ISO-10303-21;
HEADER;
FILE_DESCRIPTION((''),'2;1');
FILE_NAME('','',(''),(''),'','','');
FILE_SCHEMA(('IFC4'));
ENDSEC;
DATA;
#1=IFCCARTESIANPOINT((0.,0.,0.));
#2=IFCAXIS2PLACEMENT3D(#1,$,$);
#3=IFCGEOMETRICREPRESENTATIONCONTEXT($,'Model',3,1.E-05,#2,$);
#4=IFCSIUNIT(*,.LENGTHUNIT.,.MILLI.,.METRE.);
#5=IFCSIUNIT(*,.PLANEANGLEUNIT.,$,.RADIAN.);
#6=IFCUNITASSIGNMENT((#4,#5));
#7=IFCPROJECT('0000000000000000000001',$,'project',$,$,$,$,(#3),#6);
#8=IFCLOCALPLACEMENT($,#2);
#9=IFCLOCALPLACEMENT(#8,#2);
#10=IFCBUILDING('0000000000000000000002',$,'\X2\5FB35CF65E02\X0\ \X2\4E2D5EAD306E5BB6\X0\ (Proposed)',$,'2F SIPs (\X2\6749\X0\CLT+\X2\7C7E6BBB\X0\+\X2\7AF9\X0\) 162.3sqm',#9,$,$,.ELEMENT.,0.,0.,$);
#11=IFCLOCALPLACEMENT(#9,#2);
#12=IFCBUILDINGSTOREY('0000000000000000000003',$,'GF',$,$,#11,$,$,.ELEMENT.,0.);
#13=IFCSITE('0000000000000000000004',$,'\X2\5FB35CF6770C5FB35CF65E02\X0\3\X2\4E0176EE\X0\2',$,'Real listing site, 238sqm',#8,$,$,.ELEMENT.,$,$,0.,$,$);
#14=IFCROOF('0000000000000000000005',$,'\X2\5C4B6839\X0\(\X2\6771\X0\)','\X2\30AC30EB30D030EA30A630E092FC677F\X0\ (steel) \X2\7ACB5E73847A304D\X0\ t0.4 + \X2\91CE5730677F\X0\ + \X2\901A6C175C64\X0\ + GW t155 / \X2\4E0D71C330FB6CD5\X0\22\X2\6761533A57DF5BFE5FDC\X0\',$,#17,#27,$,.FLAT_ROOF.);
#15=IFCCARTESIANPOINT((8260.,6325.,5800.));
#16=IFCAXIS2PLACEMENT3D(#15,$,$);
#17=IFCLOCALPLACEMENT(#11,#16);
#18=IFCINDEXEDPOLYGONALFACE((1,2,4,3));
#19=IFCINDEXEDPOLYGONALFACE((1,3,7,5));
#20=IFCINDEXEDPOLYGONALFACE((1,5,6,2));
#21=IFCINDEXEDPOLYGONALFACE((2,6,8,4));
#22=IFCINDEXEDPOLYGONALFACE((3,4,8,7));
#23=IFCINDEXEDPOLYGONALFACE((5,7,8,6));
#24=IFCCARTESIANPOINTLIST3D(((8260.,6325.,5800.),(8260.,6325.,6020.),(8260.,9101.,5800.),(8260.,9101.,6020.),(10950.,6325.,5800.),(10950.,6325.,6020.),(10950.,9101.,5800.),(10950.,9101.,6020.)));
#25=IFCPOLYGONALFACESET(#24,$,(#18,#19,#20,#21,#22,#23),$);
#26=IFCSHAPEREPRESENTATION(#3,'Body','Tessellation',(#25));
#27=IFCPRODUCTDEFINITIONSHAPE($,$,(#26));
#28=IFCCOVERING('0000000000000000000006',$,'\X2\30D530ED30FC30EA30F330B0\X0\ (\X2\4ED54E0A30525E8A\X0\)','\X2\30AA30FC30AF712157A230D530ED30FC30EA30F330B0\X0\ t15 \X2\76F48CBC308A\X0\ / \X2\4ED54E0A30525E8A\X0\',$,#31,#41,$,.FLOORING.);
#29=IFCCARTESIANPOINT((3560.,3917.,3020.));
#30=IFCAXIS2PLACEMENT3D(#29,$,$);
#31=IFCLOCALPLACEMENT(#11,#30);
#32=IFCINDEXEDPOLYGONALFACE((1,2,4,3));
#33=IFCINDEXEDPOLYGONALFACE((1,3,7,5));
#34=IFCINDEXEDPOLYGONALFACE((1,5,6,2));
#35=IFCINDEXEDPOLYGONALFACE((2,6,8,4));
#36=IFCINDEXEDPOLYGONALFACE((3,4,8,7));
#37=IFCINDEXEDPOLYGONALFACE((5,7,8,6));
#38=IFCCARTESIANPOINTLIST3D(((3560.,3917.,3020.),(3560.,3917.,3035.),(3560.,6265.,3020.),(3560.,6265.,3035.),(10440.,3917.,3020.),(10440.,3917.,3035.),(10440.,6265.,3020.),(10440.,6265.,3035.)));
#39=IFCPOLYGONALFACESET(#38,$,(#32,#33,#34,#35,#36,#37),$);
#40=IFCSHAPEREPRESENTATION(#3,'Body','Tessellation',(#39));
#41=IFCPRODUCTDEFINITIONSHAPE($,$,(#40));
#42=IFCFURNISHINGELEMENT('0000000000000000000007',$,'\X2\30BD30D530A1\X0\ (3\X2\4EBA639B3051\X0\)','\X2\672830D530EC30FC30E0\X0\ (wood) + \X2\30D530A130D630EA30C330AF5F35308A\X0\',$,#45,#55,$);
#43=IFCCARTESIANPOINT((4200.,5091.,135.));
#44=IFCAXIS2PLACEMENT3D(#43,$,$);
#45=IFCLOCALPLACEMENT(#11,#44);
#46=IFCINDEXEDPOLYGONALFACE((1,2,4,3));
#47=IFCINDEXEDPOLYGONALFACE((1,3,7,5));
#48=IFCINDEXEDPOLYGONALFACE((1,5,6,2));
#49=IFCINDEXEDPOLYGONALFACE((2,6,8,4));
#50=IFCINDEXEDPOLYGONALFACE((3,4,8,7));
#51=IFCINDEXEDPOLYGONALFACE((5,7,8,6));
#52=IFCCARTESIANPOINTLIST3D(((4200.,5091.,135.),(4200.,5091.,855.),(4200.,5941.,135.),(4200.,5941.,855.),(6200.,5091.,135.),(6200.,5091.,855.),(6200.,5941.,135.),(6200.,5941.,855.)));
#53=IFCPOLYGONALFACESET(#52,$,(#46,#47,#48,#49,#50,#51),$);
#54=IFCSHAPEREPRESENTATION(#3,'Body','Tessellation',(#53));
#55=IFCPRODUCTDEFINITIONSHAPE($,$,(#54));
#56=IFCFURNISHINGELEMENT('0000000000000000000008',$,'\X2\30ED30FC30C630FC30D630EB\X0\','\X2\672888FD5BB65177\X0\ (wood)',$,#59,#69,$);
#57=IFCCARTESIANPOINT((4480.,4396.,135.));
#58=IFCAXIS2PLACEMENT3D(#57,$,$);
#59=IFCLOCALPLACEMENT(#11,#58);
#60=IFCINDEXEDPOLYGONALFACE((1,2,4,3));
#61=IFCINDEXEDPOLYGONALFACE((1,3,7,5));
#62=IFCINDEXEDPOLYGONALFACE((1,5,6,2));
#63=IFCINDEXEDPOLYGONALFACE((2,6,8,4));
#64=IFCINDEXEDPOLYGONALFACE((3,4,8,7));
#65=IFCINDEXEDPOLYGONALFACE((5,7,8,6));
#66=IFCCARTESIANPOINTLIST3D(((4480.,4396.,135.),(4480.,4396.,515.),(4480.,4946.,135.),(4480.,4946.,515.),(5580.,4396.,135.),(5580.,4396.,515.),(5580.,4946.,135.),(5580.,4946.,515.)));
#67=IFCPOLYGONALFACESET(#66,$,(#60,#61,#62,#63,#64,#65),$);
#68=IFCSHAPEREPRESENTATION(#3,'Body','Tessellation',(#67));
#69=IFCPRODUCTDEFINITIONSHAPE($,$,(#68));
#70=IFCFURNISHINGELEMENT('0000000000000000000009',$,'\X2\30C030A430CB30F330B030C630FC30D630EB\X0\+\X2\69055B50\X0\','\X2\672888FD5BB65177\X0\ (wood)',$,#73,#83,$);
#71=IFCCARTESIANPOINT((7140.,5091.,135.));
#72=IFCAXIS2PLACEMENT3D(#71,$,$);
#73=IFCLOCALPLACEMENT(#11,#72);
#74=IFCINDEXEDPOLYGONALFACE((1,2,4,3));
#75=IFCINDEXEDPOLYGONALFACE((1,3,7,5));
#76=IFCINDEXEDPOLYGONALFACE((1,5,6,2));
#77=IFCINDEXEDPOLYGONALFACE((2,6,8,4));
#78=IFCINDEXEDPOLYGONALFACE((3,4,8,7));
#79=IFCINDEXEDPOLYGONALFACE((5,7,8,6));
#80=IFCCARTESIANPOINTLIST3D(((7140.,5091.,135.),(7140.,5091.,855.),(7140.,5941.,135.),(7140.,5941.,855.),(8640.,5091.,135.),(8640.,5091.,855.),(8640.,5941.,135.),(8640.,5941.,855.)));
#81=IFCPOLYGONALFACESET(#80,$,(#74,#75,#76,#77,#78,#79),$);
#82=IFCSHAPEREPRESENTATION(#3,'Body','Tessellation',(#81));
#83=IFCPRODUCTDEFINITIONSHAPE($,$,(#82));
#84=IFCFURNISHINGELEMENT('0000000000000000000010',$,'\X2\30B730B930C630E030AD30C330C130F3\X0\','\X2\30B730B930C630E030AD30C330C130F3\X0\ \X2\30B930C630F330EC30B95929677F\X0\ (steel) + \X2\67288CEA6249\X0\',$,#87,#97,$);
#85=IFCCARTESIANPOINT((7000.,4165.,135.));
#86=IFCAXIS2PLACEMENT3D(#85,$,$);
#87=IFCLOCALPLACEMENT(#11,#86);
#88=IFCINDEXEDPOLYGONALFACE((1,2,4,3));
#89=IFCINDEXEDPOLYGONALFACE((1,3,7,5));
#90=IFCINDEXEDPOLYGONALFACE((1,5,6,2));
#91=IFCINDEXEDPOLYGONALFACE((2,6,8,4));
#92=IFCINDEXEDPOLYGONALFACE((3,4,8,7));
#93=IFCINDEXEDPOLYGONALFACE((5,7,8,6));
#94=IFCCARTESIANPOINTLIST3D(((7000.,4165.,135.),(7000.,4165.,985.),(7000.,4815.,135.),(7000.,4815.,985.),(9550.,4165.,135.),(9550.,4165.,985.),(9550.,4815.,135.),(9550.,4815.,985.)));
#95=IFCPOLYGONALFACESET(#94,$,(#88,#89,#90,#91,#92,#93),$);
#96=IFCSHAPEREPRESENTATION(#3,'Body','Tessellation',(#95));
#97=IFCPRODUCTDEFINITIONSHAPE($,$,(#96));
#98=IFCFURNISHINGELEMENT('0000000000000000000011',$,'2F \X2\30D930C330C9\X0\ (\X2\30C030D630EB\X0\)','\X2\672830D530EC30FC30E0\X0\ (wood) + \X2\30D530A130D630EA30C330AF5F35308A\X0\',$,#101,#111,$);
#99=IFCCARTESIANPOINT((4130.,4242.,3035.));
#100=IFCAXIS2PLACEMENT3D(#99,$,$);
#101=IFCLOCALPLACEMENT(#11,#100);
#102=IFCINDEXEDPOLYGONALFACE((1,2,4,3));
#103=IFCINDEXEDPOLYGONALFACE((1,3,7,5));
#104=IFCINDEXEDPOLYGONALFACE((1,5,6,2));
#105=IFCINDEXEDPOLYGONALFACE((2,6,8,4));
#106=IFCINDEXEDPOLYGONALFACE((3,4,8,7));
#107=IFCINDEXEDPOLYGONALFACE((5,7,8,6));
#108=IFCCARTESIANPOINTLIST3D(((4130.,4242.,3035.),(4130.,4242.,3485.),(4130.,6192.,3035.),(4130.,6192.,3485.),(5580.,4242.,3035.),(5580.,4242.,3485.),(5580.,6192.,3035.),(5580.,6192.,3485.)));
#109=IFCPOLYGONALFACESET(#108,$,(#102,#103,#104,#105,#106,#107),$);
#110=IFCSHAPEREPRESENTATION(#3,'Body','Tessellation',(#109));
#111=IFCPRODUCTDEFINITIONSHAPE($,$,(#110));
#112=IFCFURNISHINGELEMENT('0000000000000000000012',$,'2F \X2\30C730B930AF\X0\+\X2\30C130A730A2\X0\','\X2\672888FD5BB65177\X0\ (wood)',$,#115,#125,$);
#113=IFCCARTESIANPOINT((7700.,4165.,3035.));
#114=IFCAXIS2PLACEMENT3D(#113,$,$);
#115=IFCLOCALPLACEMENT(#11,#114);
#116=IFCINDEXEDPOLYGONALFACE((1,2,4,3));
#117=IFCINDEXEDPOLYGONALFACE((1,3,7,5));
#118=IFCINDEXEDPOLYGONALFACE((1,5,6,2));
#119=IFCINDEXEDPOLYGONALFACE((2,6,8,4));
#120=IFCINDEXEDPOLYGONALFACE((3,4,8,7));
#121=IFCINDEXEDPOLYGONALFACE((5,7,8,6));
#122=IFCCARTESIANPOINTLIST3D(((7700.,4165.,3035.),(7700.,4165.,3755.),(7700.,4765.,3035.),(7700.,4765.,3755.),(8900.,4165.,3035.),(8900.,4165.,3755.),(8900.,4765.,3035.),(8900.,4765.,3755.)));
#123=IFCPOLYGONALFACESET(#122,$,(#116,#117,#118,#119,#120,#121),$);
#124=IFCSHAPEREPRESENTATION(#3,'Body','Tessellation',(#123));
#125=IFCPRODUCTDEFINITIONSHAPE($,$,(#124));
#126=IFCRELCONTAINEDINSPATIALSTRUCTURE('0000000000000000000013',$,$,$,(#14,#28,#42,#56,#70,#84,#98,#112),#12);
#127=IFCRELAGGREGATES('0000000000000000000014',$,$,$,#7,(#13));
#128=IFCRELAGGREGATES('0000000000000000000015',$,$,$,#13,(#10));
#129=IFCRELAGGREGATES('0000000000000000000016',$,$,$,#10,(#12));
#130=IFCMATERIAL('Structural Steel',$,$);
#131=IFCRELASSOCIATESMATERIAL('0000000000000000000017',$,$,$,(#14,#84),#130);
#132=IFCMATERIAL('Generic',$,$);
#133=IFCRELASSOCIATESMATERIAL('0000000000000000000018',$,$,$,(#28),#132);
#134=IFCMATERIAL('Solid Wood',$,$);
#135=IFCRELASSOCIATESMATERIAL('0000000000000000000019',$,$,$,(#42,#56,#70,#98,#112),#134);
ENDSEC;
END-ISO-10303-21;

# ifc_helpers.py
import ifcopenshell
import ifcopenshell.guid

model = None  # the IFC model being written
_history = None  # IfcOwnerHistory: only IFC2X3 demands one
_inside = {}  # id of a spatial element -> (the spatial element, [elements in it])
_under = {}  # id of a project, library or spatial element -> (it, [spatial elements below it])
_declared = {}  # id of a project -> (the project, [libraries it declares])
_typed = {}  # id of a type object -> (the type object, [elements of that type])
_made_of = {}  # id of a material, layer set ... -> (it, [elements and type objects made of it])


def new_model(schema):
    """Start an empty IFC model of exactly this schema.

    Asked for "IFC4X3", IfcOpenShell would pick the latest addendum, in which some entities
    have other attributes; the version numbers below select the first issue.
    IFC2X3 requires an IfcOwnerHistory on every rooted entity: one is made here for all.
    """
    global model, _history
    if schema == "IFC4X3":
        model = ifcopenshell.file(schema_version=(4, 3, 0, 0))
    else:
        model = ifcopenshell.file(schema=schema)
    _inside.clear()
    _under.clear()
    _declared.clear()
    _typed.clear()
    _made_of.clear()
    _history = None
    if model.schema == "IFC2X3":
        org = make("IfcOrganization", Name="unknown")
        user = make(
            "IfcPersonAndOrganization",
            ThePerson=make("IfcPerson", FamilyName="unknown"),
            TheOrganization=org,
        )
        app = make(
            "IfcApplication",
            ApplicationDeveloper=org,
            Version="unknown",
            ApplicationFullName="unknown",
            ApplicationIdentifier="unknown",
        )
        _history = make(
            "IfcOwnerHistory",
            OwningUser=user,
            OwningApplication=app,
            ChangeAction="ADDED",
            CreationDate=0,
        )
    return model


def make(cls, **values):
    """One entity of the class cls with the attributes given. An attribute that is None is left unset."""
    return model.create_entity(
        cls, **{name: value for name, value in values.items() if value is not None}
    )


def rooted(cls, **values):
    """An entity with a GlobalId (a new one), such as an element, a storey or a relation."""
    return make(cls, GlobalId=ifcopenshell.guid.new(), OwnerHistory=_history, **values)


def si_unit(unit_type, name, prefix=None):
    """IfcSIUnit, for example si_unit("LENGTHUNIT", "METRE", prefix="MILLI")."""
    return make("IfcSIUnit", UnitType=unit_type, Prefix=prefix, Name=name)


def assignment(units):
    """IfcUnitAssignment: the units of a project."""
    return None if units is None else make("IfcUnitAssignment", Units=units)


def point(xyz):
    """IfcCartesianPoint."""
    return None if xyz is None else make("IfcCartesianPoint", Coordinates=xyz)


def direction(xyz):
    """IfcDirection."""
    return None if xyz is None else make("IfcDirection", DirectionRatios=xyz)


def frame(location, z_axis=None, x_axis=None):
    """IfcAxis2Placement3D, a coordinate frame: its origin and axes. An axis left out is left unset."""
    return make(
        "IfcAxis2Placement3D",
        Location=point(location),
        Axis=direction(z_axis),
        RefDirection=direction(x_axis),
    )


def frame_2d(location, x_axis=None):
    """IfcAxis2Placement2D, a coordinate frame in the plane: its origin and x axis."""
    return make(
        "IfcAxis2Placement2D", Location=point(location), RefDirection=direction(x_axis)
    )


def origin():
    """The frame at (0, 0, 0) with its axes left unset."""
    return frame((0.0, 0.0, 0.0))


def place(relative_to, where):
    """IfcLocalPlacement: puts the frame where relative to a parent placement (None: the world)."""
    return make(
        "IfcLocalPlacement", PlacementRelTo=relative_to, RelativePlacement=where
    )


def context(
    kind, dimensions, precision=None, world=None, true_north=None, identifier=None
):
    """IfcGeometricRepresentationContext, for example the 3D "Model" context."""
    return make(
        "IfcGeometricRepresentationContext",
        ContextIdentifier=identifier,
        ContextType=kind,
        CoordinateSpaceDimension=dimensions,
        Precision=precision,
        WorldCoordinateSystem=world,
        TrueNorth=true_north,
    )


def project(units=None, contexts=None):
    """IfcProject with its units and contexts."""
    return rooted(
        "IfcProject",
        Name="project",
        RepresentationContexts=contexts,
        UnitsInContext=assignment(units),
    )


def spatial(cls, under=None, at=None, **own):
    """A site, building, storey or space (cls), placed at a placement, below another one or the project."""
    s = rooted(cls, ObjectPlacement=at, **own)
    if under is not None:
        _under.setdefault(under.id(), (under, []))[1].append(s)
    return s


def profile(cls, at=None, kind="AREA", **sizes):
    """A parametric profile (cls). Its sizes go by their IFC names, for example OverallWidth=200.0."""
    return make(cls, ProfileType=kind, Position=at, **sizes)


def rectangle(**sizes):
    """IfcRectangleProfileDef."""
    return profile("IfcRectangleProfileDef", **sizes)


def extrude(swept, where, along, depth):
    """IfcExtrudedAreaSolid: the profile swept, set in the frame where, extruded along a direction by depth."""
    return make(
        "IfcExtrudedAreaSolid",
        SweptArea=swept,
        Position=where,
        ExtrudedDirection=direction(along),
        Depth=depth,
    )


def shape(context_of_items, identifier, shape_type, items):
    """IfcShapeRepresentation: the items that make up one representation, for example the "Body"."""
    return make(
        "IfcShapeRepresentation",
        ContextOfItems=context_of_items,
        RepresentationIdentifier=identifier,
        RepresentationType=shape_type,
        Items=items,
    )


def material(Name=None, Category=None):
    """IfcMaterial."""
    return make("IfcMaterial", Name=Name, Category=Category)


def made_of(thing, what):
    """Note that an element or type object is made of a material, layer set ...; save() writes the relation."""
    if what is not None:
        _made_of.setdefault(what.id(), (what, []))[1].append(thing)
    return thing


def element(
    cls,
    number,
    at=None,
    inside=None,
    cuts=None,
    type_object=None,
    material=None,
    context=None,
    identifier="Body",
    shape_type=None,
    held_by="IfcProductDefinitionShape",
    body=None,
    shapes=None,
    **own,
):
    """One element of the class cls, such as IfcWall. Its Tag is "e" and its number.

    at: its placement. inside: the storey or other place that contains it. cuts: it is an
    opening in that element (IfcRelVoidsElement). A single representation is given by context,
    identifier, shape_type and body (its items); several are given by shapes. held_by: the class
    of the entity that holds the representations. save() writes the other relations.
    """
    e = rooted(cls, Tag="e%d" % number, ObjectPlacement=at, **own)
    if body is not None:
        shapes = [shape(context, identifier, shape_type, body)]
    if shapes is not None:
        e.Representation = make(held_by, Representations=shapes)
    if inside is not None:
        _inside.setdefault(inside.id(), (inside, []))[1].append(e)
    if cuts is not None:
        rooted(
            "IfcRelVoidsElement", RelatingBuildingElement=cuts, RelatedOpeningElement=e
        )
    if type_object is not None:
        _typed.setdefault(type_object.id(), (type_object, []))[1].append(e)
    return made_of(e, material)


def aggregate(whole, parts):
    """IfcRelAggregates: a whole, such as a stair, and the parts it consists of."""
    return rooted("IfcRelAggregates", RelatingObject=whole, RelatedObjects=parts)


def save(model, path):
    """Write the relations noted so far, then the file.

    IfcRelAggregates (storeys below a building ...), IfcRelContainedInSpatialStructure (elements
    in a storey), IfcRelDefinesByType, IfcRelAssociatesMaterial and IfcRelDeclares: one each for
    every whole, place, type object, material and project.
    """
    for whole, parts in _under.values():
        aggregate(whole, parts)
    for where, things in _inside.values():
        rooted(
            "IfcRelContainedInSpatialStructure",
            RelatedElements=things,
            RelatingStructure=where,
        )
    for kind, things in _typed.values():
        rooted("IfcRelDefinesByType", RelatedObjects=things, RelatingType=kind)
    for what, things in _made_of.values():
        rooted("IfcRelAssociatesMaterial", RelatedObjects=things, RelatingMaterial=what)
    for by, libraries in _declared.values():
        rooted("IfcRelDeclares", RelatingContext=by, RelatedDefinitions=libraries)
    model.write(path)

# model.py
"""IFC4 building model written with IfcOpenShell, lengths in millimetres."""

from ifc_helpers import new_model, si_unit, frame, frame_2d, origin, place, context, project, spatial, rectangle, extrude, material, element, save


model = new_model("IFC4")

# Units and contexts
model_context = context("Model", 3, precision=1e-05, world=origin())
ifc_project = project(units=[si_unit("LENGTHUNIT", "METRE", prefix="MILLI"), si_unit("PLANEANGLEUNIT", "RADIAN")], contexts=[model_context])

# Site, building, storey
site_placement = place(None, origin())
site = spatial("IfcSite", under=ifc_project, at=site_placement, Name="徳島県徳島市3丁目2", ObjectType="Real listing site, 238sqm", CompositionType="ELEMENT", RefElevation=0.0)
building_placement = place(site_placement, origin())
building = spatial("IfcBuilding", under=site, at=building_placement, Name="徳島市 中庭の家 (Proposed)", ObjectType="2F SIPs (杉CLT+籾殻+竹) 162.3sqm", CompositionType="ELEMENT", ElevationOfRefHeight=0.0, ElevationOfTerrain=0.0)
storey_placement = place(building_placement, origin())
storey = spatial("IfcBuildingStorey", under=building, at=storey_placement, Name="GF", CompositionType="ELEMENT", Elevation=0.0)

# Shared definitions
ifc_material_1 = material(Name="Solid Wood")

# Shared definitions
ifc_material_2 = material(Name="Generic")

# Roof
ifc_material_3 = material(Name="Structural Steel")
roof_placement = place(storey_placement, frame((8260.0, 6325.0, 5800.0)))
element("IfcRoof", 1, at=roof_placement, inside=storey, material=ifc_material_3, Name="屋根(東)", Description="ガルバリウム鋼板 (steel) 立平葺き t0.4 + 野地板 + 通気層 + GW t155 / 不燃・法22条区域対応", PredefinedType="FLAT_ROOF", context=model_context, shape_type="SweptSolid", body=[
    extrude(rectangle(XDim=2690.0, YDim=2776.0, at=frame_2d((1345.0, 1388.0))), frame((8260.0, 6325.0, 5800.0)), (0.0, 0.0, 1.0), 220.0),
])

# Covering
covering_placement = place(storey_placement, frame((3560.0, 3917.0, 3020.0)))
element("IfcCovering", 2, at=covering_placement, inside=storey, material=ifc_material_2, Name="フローリング (仕上げ床)", Description="オーク無垢フローリング t15 直貼り / 仕上げ床", PredefinedType="FLOORING", context=model_context, shape_type="SweptSolid", body=[
    extrude(rectangle(XDim=6880.0, YDim=2348.0, at=frame_2d((3440.0, 1174.0))), frame((3560.0, 3917.0, 3020.0)), (0.0, 0.0, 1.0), 15.0),
])

# Furnishing elements
furnishing_1_placement = place(storey_placement, frame((4200.0, 5091.0, 135.0)))
element("IfcFurnishingElement", 3, at=furnishing_1_placement, inside=storey, material=ifc_material_1, Name="ソファ (3人掛け)", Description="木フレーム (wood) + ファブリック張り", context=model_context, shape_type="SweptSolid", body=[
    extrude(rectangle(XDim=2000.0, YDim=850.0, at=frame_2d((1000.0, 425.0))), frame((4200.0, 5091.0, 135.0)), (0.0, 0.0, 1.0), 720.0),
])
furnishing_2_placement = place(storey_placement, frame((4480.0, 4396.0, 135.0)))
element("IfcFurnishingElement", 4, at=furnishing_2_placement, inside=storey, material=ifc_material_1, Name="ローテーブル", Description="木製家具 (wood)", context=model_context, shape_type="SweptSolid", body=[
    extrude(rectangle(XDim=1100.0, YDim=550.0, at=frame_2d((550.0, 275.0))), frame((4480.0, 4396.0, 135.0)), (0.0, 0.0, 1.0), 380.0),
])
furnishing_3_placement = place(storey_placement, frame((7140.0, 5091.0, 135.0)))
element("IfcFurnishingElement", 5, at=furnishing_3_placement, inside=storey, material=ifc_material_1, Name="ダイニングテーブル+椅子", Description="木製家具 (wood)", context=model_context, shape_type="SweptSolid", body=[
    extrude(rectangle(XDim=1500.0, YDim=850.0, at=frame_2d((750.0, 425.0))), frame((7140.0, 5091.0, 135.0)), (0.0, 0.0, 1.0), 720.0),
])
furnishing_4_placement = place(storey_placement, frame((7000.0, 4165.0, 135.0)))
element("IfcFurnishingElement", 6, at=furnishing_4_placement, inside=storey, material=ifc_material_3, Name="システムキッチン", Description="システムキッチン ステンレス天板 (steel) + 木質扉", context=model_context, shape_type="SweptSolid", body=[
    extrude(rectangle(XDim=2550.0, YDim=650.0, at=frame_2d((1275.0, 325.0))), frame((7000.0, 4165.0, 135.0)), (0.0, 0.0, 1.0), 850.0),
])
furnishing_5_placement = place(storey_placement, frame((4130.0, 4242.0, 3035.0)))
element("IfcFurnishingElement", 7, at=furnishing_5_placement, inside=storey, material=ifc_material_1, Name="2F ベッド (ダブル)", Description="木フレーム (wood) + ファブリック張り", context=model_context, shape_type="SweptSolid", body=[
    extrude(rectangle(XDim=1450.0, YDim=1950.0, at=frame_2d((725.0, 975.0))), frame((4130.0, 4242.0, 3035.0)), (0.0, 0.0, 1.0), 450.0),
])
furnishing_6_placement = place(storey_placement, frame((7700.0, 4165.0, 3035.0)))
element("IfcFurnishingElement", 8, at=furnishing_6_placement, inside=storey, material=ifc_material_1, Name="2F デスク+チェア", Description="木製家具 (wood)", context=model_context, shape_type="SweptSolid", body=[
    extrude(rectangle(XDim=1200.0, YDim=600.0, at=frame_2d((600.0, 300.0))), frame((7700.0, 4165.0, 3035.0)), (0.0, 0.0, 1.0), 720.0),
])

save(model, "model.ifc")
